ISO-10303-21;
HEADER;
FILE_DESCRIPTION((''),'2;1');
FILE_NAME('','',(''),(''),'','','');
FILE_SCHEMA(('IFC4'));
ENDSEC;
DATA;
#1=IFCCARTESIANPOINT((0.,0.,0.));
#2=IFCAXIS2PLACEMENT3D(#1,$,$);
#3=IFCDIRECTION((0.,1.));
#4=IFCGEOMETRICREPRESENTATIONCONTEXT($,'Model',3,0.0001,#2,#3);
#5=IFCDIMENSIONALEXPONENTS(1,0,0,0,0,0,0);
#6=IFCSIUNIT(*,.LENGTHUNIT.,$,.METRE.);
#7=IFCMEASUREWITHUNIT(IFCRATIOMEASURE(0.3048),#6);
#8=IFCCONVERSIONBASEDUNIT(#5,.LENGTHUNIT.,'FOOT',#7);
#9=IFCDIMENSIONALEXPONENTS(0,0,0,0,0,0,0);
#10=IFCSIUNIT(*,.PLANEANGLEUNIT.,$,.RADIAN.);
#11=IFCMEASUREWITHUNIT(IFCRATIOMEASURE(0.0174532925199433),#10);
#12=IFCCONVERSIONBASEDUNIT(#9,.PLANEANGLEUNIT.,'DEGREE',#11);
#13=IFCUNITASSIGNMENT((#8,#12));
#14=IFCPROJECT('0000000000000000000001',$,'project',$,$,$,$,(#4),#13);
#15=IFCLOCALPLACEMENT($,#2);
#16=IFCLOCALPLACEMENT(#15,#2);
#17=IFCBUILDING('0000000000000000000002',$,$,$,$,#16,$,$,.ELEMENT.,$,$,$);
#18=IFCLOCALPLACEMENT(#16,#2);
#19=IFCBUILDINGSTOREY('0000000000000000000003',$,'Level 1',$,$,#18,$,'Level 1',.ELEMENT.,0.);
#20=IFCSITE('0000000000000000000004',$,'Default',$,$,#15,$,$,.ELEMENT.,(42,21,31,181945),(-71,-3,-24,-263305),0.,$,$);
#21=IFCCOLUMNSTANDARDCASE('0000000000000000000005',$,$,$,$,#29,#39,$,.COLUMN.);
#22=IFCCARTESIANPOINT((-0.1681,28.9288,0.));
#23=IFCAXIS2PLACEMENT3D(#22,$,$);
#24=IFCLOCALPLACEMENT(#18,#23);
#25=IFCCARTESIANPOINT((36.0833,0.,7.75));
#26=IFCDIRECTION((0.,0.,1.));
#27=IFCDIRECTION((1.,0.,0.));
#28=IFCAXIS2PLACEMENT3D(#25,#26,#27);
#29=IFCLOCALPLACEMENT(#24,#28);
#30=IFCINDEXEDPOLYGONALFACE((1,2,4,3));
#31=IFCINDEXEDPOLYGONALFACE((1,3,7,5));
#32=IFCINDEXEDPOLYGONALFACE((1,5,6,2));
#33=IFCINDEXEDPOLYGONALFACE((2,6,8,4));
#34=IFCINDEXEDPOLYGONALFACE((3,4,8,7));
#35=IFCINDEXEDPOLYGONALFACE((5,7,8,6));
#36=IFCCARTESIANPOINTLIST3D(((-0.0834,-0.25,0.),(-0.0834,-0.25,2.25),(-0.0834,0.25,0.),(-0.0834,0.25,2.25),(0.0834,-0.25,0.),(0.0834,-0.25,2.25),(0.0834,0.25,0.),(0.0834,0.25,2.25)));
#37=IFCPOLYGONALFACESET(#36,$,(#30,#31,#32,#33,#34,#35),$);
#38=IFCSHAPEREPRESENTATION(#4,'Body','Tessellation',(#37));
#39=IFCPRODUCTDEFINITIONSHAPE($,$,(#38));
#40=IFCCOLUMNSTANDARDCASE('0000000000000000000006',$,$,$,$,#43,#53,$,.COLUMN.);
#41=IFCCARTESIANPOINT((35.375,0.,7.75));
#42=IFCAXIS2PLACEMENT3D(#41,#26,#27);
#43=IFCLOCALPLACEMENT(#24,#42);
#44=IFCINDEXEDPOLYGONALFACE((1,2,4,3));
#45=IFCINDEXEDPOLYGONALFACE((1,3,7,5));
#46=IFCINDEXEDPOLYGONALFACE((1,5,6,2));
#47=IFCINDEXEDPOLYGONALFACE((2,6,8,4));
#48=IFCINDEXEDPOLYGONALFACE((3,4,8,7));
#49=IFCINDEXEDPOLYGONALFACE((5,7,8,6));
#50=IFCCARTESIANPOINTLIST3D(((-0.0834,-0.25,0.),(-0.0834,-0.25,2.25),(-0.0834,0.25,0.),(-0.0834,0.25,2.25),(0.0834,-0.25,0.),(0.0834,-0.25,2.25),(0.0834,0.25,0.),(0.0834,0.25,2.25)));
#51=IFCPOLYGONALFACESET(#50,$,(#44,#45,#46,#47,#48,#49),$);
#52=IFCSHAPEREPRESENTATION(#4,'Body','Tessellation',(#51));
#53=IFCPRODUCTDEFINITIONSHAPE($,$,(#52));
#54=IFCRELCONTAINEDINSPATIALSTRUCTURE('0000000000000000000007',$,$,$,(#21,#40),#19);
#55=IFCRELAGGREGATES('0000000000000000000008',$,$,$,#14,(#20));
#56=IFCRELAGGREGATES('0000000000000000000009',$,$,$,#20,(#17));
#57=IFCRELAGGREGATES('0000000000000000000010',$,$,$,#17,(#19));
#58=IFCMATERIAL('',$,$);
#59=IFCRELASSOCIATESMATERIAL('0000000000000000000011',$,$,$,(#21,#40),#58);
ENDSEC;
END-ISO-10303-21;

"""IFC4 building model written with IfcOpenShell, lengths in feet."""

from ifc_helpers import new_model, entity, si_unit, converted_unit, direction, frame, origin, place, context, project, spatial, rectangle, extrude, material, element, save


model = new_model("IFC4")

# Units and contexts
model_context = context("Model", 3, precision=0.0001, world=origin(), true_north=direction((0.0, 1.0)))
ifc_project = project(units=[converted_unit("LENGTHUNIT", "FOOT", entity("IfcRatioMeasure", 0.3048), si_unit("LENGTHUNIT", "METRE"), dimensions=[1, 0, 0, 0, 0, 0, 0]), converted_unit("PLANEANGLEUNIT", "DEGREE", entity("IfcRatioMeasure", 0.0174532925199433), si_unit("PLANEANGLEUNIT", "RADIAN"), dimensions=[0, 0, 0, 0, 0, 0, 0])], contexts=[model_context])

# Site, building, storey
site_placement = place(None, origin())
site = spatial("IfcSite", under=ifc_project, at=site_placement, Name="Default", CompositionType="ELEMENT", RefLatitude=(42, 21, 31, 181945), RefLongitude=(-71, -3, -24, -263305), RefElevation=0.0)
building_placement = place(site_placement, origin())
building = spatial("IfcBuilding", under=site, at=building_placement, CompositionType="ELEMENT")
storey_placement = place(building_placement, origin())
storey = spatial("IfcBuildingStorey", under=building, at=storey_placement, Name="Level 1", LongName="Level 1", CompositionType="ELEMENT", Elevation=0.0)

# Columns
placement = place(storey_placement, frame((-0.1681, 28.9288, 0.0)))
ifc_material_1 = material(Name="")
for number, where, z_axis, x_axis in (
    (1, (36.0833, 0.0, 7.75), (0.0, 0.0, 1.0), (1.0, 0.0, 0.0)),
    (2, (35.375, 0.0, 7.75), (0.0, 0.0, 1.0), (1.0, 0.0, 0.0)),
):
    element("IfcColumnStandardCase", number, at=place(placement, frame(where, z_axis=z_axis, x_axis=x_axis)), inside=storey, material=ifc_material_1, PredefinedType="COLUMN", context=model_context, shape_type="SweptSolid", body=[
        extrude(rectangle(XDim=0.1667, YDim=0.5), origin(), (0.0, 0.0, 1.0), 2.25),
    ])

save(model, "model.ifc")
